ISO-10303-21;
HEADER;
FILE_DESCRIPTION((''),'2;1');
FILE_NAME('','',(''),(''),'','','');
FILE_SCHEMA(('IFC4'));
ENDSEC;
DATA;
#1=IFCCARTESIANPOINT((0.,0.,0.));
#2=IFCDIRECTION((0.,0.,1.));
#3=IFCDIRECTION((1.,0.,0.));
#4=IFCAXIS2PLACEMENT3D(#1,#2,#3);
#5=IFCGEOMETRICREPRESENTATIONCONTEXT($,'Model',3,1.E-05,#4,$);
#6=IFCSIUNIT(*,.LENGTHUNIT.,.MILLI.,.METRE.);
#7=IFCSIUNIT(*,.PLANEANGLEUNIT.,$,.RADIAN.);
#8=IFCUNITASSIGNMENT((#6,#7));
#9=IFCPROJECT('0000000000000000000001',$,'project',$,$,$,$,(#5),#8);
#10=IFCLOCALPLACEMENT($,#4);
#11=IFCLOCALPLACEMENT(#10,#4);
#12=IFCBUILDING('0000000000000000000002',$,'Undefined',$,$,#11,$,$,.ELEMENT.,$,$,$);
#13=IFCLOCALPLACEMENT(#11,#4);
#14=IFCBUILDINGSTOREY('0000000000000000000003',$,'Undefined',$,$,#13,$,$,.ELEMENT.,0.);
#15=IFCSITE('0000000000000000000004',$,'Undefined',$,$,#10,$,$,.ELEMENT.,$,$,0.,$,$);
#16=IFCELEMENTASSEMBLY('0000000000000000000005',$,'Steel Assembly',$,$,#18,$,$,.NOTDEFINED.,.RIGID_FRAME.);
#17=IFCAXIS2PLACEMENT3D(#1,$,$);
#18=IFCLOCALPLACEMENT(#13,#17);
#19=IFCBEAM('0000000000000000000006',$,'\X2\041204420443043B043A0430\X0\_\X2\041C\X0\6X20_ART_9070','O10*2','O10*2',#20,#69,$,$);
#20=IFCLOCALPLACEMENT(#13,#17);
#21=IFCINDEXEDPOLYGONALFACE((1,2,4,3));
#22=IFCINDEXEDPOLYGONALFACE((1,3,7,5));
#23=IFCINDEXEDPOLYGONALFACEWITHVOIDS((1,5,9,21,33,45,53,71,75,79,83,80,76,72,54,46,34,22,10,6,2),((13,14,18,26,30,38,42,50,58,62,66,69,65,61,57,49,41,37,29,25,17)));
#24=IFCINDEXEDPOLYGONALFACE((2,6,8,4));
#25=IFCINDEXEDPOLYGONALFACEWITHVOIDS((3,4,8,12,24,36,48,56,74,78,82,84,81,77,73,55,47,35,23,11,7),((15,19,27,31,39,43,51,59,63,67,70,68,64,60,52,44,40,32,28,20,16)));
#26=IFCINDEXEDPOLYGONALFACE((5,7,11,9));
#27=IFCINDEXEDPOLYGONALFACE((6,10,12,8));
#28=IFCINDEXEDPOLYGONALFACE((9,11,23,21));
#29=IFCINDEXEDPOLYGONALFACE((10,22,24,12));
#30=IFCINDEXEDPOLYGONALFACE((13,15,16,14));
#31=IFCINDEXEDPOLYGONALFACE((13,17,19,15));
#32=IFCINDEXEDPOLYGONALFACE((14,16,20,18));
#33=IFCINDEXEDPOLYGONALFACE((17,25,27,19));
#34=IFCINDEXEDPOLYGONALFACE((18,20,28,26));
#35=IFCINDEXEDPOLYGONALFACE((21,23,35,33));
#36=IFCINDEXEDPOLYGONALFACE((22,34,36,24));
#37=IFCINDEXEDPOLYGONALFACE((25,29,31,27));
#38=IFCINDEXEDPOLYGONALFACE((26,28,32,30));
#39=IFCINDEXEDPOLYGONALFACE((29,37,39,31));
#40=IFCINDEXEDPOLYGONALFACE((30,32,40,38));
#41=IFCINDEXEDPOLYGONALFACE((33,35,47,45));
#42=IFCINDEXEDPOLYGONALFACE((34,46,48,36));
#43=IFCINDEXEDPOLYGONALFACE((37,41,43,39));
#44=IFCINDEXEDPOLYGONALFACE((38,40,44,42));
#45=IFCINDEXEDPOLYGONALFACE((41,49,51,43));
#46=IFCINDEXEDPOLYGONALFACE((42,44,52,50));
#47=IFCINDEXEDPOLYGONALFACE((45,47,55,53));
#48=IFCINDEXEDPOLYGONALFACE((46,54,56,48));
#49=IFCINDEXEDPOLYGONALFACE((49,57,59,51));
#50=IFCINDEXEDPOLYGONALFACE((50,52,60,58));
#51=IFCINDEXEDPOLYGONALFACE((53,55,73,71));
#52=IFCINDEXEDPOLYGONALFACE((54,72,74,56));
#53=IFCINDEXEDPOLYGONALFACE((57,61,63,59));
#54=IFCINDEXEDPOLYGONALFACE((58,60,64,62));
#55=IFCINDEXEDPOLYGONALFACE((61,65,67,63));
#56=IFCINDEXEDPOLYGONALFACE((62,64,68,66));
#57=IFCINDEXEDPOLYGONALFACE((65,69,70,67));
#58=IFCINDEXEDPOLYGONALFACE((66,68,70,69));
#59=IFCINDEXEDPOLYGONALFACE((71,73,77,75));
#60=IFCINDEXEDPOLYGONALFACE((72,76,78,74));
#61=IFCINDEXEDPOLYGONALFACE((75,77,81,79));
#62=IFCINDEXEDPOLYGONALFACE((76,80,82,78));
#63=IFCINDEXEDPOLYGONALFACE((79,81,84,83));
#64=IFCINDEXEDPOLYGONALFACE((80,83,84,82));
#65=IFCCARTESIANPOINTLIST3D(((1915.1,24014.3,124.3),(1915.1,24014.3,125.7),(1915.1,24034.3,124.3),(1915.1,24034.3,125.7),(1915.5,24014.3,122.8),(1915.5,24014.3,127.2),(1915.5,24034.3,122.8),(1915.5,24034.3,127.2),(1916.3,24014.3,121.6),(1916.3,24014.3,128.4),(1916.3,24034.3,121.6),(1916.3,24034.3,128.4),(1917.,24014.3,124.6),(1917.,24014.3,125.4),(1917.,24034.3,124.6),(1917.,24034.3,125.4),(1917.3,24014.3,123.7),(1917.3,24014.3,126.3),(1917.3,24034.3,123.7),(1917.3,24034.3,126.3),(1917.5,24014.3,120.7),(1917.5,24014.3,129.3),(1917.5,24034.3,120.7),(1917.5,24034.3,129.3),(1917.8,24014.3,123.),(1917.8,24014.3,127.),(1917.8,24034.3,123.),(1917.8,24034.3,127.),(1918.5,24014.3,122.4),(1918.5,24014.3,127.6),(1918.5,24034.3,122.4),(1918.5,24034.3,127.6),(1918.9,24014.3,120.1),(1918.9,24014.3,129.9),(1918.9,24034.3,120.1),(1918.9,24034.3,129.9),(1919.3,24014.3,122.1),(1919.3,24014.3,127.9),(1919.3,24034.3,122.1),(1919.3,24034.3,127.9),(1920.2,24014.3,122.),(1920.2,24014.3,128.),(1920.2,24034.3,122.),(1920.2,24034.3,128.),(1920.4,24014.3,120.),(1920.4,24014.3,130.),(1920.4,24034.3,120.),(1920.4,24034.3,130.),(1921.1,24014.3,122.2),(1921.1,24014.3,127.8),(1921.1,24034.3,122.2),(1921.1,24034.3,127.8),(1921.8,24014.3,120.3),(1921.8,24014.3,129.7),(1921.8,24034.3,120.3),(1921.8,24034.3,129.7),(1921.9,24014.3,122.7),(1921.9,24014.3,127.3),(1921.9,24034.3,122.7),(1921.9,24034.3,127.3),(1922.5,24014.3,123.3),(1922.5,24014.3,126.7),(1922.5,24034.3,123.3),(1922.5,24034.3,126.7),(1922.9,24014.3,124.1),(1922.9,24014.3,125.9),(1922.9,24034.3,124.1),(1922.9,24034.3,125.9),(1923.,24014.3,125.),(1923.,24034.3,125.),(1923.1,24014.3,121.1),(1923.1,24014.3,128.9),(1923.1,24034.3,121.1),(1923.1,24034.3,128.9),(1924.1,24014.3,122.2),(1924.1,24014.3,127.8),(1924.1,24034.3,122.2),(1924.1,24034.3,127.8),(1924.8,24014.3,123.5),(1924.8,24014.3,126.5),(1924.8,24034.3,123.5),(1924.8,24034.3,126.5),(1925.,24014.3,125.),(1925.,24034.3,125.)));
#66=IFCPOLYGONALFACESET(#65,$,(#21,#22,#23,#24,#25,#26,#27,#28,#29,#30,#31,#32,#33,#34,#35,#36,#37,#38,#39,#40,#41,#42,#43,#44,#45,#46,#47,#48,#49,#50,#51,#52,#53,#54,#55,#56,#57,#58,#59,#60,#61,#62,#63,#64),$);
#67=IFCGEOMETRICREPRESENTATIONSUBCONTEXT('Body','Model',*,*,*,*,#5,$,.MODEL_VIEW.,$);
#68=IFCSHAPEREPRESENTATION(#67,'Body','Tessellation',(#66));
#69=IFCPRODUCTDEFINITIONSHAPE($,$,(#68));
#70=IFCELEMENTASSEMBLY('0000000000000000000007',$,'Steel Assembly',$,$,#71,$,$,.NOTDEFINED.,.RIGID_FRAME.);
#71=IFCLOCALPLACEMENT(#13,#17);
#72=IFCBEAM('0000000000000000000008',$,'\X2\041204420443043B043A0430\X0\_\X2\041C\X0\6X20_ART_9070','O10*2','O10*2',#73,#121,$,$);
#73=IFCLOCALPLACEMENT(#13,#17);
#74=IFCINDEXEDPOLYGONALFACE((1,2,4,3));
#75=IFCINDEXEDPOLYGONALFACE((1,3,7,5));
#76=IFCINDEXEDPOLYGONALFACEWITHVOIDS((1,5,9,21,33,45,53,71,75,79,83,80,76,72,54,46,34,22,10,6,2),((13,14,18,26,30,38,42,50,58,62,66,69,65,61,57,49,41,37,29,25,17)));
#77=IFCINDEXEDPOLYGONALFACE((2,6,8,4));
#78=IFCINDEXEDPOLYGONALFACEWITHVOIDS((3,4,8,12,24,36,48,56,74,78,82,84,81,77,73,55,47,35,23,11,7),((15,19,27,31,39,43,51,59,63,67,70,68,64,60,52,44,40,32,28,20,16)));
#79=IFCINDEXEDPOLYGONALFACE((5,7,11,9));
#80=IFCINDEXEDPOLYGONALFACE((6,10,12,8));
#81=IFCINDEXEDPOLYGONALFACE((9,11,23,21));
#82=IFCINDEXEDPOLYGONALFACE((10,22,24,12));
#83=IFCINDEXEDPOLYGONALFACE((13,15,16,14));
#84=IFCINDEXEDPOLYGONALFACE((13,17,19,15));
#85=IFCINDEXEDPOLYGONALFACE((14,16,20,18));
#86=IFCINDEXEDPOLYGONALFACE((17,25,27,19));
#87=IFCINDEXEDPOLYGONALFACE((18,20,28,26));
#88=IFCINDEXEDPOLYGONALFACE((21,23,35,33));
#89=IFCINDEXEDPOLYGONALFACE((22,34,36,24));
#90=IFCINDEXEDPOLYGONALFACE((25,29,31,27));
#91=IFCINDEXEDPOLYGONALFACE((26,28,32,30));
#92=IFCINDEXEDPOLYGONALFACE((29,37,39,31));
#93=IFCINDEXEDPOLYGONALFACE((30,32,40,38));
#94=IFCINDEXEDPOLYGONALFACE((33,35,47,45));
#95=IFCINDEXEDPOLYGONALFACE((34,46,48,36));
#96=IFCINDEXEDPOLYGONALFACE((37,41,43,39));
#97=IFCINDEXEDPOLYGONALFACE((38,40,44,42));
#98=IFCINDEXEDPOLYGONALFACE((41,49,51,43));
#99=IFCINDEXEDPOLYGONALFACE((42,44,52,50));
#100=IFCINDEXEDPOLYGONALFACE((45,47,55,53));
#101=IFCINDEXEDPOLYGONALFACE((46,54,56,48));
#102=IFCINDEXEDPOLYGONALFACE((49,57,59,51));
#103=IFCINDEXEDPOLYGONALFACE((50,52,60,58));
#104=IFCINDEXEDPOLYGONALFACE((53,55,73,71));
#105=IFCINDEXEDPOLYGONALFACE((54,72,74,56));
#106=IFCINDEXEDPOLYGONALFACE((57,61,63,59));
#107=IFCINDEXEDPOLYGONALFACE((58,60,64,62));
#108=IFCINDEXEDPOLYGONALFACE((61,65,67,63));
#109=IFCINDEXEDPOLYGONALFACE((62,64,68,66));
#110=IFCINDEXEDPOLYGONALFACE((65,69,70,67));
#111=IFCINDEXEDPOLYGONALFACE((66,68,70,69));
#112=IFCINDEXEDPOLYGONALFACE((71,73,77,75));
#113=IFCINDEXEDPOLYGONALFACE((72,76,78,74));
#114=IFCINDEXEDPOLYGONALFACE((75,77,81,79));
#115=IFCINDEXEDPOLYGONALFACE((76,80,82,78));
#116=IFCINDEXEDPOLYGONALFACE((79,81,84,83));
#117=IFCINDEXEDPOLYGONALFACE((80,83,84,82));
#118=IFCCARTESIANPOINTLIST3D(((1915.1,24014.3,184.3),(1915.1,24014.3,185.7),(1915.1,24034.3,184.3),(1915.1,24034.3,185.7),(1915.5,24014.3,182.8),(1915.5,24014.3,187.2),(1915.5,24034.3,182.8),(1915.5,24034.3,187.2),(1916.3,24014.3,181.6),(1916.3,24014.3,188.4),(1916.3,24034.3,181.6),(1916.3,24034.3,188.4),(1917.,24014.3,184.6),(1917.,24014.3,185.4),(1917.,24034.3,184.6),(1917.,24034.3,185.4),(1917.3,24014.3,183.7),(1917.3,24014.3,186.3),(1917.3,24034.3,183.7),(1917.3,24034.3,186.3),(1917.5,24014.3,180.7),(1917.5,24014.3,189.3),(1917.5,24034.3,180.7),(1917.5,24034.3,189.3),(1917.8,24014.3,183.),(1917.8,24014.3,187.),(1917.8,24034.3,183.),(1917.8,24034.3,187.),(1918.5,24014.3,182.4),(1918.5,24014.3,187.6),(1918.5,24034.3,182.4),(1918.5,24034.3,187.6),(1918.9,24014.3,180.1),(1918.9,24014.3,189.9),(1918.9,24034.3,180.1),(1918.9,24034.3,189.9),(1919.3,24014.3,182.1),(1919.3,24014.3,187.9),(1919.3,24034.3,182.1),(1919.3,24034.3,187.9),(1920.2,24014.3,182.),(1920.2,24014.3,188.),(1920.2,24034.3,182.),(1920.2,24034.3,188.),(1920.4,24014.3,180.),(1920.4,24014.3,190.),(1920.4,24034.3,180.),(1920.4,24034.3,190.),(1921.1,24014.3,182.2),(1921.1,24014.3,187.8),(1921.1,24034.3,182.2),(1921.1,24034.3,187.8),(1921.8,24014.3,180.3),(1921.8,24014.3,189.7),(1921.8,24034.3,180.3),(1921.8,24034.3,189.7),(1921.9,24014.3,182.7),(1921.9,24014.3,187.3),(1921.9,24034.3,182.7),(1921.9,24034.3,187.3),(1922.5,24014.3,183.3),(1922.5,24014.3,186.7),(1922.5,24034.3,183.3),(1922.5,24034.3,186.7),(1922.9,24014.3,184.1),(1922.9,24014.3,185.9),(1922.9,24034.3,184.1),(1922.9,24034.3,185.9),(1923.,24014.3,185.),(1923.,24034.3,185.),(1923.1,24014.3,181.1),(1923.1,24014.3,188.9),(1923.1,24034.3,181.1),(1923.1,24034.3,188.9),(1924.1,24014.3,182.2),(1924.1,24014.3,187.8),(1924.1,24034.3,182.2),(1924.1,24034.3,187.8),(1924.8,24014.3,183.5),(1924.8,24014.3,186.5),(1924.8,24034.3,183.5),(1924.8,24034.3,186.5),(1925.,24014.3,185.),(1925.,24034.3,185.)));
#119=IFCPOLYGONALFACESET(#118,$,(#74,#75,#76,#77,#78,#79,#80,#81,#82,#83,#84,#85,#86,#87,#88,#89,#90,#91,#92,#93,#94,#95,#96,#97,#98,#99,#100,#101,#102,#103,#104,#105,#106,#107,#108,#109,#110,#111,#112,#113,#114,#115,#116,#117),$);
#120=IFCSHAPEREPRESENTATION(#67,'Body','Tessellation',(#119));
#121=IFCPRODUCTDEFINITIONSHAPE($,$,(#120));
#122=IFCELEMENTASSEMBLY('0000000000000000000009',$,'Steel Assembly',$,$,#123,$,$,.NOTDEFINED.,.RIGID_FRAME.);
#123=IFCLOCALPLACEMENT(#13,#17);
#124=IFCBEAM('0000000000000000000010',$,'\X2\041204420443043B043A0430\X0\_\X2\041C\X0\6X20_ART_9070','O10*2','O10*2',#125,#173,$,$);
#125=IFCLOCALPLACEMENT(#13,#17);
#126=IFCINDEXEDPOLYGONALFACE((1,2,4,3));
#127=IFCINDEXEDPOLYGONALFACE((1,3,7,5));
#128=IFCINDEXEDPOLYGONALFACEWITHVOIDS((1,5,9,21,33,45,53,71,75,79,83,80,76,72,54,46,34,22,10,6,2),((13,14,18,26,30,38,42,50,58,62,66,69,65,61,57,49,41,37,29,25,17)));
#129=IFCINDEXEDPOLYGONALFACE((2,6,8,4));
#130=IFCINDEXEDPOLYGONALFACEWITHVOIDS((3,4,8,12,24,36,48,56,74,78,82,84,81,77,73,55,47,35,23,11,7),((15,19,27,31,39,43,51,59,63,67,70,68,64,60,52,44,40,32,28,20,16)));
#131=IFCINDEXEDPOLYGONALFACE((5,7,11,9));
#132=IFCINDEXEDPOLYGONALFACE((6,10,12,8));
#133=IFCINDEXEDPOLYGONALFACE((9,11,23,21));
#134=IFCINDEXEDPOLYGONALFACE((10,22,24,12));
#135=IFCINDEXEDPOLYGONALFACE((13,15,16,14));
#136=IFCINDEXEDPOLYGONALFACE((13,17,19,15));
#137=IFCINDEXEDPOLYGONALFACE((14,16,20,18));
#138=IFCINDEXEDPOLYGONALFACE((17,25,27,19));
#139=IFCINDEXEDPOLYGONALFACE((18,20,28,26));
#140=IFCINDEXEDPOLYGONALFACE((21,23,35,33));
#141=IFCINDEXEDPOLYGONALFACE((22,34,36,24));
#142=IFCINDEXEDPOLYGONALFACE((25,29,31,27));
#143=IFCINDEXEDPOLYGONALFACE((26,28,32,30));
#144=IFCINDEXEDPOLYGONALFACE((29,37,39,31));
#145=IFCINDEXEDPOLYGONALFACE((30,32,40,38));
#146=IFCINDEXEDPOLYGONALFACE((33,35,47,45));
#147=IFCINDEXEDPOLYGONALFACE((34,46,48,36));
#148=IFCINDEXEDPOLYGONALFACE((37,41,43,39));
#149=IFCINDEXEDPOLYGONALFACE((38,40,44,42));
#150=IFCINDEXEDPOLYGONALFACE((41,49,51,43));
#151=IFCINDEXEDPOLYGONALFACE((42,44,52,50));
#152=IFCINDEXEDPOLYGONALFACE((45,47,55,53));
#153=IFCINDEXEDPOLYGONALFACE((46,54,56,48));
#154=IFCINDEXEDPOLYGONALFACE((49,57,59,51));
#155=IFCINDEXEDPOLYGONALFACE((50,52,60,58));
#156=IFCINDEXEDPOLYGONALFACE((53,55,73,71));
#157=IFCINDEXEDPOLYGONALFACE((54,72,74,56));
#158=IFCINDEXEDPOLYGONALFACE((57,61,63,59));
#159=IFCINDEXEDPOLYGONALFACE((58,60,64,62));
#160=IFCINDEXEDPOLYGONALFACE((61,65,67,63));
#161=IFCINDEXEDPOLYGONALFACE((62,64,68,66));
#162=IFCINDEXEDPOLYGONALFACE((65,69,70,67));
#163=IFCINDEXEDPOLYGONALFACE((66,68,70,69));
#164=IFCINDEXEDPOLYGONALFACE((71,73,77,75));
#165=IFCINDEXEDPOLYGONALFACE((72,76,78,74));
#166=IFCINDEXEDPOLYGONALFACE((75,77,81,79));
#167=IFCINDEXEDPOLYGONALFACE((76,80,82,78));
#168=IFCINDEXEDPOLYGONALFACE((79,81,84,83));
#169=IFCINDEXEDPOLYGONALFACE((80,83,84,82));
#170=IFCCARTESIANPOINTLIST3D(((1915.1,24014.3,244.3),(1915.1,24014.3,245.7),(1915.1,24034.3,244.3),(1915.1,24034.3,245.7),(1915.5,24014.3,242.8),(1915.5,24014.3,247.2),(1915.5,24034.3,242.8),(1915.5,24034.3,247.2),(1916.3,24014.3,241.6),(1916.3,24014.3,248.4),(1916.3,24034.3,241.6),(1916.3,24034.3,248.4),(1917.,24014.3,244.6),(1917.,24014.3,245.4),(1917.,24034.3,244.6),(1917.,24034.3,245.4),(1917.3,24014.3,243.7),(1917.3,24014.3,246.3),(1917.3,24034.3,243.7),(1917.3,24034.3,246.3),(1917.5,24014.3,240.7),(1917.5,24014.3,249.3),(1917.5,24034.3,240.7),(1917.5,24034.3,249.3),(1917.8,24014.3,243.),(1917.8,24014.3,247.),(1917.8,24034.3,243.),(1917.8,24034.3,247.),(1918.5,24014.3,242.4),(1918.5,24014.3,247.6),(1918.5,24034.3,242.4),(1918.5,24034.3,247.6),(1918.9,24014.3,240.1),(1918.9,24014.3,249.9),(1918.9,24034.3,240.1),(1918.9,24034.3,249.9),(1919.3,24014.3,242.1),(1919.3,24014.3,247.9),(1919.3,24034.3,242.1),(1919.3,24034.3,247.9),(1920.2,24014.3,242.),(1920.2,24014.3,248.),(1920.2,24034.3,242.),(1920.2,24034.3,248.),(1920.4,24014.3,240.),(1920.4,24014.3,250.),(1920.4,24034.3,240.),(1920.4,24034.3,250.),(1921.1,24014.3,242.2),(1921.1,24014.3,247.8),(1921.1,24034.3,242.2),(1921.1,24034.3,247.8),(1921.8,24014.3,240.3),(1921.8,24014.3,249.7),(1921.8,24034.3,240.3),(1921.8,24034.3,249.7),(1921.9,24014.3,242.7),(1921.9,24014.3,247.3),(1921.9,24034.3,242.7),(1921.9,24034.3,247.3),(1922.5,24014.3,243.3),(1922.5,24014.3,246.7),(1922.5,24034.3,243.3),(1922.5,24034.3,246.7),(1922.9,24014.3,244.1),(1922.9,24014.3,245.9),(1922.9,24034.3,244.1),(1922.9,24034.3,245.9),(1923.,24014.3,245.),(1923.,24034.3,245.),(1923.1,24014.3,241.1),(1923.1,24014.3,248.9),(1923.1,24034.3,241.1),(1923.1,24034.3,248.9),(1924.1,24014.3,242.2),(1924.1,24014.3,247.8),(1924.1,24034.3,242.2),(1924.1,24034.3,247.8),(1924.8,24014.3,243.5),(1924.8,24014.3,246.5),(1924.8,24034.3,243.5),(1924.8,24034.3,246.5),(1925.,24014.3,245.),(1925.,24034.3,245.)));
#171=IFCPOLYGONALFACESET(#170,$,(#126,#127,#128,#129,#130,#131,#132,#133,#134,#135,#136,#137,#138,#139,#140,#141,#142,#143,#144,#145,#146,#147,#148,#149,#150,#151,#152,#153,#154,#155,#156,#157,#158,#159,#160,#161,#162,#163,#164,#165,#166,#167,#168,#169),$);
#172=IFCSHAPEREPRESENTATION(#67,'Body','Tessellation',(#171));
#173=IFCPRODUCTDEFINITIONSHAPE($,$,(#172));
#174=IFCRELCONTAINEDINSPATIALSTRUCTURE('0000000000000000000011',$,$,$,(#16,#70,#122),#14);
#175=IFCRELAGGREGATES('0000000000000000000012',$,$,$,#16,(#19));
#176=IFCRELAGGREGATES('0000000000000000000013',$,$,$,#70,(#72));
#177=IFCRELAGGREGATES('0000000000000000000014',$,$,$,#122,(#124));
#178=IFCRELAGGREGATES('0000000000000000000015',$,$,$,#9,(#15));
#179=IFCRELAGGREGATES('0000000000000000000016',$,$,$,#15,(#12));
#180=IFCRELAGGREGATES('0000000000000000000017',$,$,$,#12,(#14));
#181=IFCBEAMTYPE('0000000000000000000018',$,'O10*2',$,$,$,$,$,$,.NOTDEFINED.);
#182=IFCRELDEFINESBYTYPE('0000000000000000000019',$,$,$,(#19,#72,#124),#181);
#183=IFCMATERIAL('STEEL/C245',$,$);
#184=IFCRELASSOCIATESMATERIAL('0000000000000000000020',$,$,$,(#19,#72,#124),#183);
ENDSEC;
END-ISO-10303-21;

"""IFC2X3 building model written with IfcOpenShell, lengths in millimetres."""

from ifc_helpers import new_model, si_unit, frame, origin_with_axes, origin_2d_with_axis, place, context, subcontext, project, spatial, hollow_circle, extrude, material, type_object, element, aggregate, save


model = new_model("IFC2X3")

# Units and contexts
model_context = context("Model", 3, precision=1e-05, world=origin_with_axes())
body_context = subcontext(model_context, "Body", "Model", "MODEL_VIEW")
ifc_project = project(units=[si_unit("LENGTHUNIT", "METRE", prefix="MILLI"), si_unit("PLANEANGLEUNIT", "RADIAN")], contexts=[model_context])

# Site, building, storey
site_placement = place(None, origin_with_axes())
site = spatial("IfcSite", under=ifc_project, at=site_placement, Name="Undefined", CompositionType="ELEMENT", RefElevation=0.0)
building_placement = place(site_placement, origin_with_axes())
building = spatial("IfcBuilding", under=site, at=building_placement, Name="Undefined", CompositionType="ELEMENT")
storey_placement = place(building_placement, origin_with_axes())
storey = spatial("IfcBuildingStorey", under=building, at=storey_placement, Name="Undefined", CompositionType="ELEMENT", Elevation=0.0)

# Element assemblies, beams
ifc_material_1 = material(Name="STEEL/C245")
beam_type_1 = type_object("IfcBeamType", Name="O10*2", PredefinedType="NOTDEFINED")
assembly_1_placement = place(storey_placement, origin_with_axes())
assembly_1 = element("IfcElementAssembly", 1, at=assembly_1_placement, inside=storey, Name="Steel Assembly", AssemblyPlace="NOTDEFINED", PredefinedType="RIGID_FRAME")
beam_1_placement = place(assembly_1_placement, frame((1920.0, 24014.3, 125.0), z_axis=(0.0, 0.0, 1.0), x_axis=(0.0, 1.0, 0.0)))
beam_1 = element("IfcBeam", 2, at=beam_1_placement, type_object=beam_type_1, material=ifc_material_1, Name="Втулка_М6X20_ART_9070", Description="O10*2", ObjectType="O10*2", context=body_context, shape_type="SweptSolid", body=[
    extrude(hollow_circle(Radius=5.0, WallThickness=2.0, at=origin_2d_with_axis()), frame((20.0, 0.0, 0.0), z_axis=(-1.0, 0.0, 0.0), x_axis=(0.0, -1.0, 0.0)), (0.0, 0.0, 1.0), 20.0),
])
aggregate(assembly_1, [beam_1])
assembly_2_placement = place(storey_placement, origin_with_axes())
assembly_2 = element("IfcElementAssembly", 3, at=assembly_2_placement, inside=storey, Name="Steel Assembly", AssemblyPlace="NOTDEFINED", PredefinedType="RIGID_FRAME")
beam_2_placement = place(assembly_2_placement, frame((1920.0, 24014.3, 185.0), z_axis=(0.0, 0.0, 1.0), x_axis=(0.0, 1.0, 0.0)))
beam_2 = element("IfcBeam", 4, at=beam_2_placement, type_object=beam_type_1, material=ifc_material_1, Name="Втулка_М6X20_ART_9070", Description="O10*2", ObjectType="O10*2", context=body_context, shape_type="SweptSolid", body=[
    extrude(hollow_circle(Radius=5.0, WallThickness=2.0, at=origin_2d_with_axis()), frame((20.0, 0.0, 0.0), z_axis=(-1.0, 0.0, 0.0), x_axis=(0.0, -1.0, 0.0)), (0.0, 0.0, 1.0), 20.0),
])
aggregate(assembly_2, [beam_2])
assembly_3_placement = place(storey_placement, origin_with_axes())
assembly_3 = element("IfcElementAssembly", 5, at=assembly_3_placement, inside=storey, Name="Steel Assembly", AssemblyPlace="NOTDEFINED", PredefinedType="RIGID_FRAME")
beam_3_placement = place(assembly_3_placement, frame((1920.0, 24014.3, 245.0), z_axis=(0.0, 0.0, 1.0), x_axis=(0.0, 1.0, 0.0)))
beam_3 = element("IfcBeam", 6, at=beam_3_placement, type_object=beam_type_1, material=ifc_material_1, Name="Втулка_М6X20_ART_9070", Description="O10*2", ObjectType="O10*2", context=body_context, shape_type="SweptSolid", body=[
    extrude(hollow_circle(Radius=5.0, WallThickness=2.0, at=origin_2d_with_axis()), frame((20.0, 0.0, 0.0), z_axis=(-1.0, 0.0, 0.0), x_axis=(0.0, -1.0, 0.0)), (0.0, 0.0, 1.0), 20.0),
])
aggregate(assembly_3, [beam_3])

save(model, "model.ifc")
